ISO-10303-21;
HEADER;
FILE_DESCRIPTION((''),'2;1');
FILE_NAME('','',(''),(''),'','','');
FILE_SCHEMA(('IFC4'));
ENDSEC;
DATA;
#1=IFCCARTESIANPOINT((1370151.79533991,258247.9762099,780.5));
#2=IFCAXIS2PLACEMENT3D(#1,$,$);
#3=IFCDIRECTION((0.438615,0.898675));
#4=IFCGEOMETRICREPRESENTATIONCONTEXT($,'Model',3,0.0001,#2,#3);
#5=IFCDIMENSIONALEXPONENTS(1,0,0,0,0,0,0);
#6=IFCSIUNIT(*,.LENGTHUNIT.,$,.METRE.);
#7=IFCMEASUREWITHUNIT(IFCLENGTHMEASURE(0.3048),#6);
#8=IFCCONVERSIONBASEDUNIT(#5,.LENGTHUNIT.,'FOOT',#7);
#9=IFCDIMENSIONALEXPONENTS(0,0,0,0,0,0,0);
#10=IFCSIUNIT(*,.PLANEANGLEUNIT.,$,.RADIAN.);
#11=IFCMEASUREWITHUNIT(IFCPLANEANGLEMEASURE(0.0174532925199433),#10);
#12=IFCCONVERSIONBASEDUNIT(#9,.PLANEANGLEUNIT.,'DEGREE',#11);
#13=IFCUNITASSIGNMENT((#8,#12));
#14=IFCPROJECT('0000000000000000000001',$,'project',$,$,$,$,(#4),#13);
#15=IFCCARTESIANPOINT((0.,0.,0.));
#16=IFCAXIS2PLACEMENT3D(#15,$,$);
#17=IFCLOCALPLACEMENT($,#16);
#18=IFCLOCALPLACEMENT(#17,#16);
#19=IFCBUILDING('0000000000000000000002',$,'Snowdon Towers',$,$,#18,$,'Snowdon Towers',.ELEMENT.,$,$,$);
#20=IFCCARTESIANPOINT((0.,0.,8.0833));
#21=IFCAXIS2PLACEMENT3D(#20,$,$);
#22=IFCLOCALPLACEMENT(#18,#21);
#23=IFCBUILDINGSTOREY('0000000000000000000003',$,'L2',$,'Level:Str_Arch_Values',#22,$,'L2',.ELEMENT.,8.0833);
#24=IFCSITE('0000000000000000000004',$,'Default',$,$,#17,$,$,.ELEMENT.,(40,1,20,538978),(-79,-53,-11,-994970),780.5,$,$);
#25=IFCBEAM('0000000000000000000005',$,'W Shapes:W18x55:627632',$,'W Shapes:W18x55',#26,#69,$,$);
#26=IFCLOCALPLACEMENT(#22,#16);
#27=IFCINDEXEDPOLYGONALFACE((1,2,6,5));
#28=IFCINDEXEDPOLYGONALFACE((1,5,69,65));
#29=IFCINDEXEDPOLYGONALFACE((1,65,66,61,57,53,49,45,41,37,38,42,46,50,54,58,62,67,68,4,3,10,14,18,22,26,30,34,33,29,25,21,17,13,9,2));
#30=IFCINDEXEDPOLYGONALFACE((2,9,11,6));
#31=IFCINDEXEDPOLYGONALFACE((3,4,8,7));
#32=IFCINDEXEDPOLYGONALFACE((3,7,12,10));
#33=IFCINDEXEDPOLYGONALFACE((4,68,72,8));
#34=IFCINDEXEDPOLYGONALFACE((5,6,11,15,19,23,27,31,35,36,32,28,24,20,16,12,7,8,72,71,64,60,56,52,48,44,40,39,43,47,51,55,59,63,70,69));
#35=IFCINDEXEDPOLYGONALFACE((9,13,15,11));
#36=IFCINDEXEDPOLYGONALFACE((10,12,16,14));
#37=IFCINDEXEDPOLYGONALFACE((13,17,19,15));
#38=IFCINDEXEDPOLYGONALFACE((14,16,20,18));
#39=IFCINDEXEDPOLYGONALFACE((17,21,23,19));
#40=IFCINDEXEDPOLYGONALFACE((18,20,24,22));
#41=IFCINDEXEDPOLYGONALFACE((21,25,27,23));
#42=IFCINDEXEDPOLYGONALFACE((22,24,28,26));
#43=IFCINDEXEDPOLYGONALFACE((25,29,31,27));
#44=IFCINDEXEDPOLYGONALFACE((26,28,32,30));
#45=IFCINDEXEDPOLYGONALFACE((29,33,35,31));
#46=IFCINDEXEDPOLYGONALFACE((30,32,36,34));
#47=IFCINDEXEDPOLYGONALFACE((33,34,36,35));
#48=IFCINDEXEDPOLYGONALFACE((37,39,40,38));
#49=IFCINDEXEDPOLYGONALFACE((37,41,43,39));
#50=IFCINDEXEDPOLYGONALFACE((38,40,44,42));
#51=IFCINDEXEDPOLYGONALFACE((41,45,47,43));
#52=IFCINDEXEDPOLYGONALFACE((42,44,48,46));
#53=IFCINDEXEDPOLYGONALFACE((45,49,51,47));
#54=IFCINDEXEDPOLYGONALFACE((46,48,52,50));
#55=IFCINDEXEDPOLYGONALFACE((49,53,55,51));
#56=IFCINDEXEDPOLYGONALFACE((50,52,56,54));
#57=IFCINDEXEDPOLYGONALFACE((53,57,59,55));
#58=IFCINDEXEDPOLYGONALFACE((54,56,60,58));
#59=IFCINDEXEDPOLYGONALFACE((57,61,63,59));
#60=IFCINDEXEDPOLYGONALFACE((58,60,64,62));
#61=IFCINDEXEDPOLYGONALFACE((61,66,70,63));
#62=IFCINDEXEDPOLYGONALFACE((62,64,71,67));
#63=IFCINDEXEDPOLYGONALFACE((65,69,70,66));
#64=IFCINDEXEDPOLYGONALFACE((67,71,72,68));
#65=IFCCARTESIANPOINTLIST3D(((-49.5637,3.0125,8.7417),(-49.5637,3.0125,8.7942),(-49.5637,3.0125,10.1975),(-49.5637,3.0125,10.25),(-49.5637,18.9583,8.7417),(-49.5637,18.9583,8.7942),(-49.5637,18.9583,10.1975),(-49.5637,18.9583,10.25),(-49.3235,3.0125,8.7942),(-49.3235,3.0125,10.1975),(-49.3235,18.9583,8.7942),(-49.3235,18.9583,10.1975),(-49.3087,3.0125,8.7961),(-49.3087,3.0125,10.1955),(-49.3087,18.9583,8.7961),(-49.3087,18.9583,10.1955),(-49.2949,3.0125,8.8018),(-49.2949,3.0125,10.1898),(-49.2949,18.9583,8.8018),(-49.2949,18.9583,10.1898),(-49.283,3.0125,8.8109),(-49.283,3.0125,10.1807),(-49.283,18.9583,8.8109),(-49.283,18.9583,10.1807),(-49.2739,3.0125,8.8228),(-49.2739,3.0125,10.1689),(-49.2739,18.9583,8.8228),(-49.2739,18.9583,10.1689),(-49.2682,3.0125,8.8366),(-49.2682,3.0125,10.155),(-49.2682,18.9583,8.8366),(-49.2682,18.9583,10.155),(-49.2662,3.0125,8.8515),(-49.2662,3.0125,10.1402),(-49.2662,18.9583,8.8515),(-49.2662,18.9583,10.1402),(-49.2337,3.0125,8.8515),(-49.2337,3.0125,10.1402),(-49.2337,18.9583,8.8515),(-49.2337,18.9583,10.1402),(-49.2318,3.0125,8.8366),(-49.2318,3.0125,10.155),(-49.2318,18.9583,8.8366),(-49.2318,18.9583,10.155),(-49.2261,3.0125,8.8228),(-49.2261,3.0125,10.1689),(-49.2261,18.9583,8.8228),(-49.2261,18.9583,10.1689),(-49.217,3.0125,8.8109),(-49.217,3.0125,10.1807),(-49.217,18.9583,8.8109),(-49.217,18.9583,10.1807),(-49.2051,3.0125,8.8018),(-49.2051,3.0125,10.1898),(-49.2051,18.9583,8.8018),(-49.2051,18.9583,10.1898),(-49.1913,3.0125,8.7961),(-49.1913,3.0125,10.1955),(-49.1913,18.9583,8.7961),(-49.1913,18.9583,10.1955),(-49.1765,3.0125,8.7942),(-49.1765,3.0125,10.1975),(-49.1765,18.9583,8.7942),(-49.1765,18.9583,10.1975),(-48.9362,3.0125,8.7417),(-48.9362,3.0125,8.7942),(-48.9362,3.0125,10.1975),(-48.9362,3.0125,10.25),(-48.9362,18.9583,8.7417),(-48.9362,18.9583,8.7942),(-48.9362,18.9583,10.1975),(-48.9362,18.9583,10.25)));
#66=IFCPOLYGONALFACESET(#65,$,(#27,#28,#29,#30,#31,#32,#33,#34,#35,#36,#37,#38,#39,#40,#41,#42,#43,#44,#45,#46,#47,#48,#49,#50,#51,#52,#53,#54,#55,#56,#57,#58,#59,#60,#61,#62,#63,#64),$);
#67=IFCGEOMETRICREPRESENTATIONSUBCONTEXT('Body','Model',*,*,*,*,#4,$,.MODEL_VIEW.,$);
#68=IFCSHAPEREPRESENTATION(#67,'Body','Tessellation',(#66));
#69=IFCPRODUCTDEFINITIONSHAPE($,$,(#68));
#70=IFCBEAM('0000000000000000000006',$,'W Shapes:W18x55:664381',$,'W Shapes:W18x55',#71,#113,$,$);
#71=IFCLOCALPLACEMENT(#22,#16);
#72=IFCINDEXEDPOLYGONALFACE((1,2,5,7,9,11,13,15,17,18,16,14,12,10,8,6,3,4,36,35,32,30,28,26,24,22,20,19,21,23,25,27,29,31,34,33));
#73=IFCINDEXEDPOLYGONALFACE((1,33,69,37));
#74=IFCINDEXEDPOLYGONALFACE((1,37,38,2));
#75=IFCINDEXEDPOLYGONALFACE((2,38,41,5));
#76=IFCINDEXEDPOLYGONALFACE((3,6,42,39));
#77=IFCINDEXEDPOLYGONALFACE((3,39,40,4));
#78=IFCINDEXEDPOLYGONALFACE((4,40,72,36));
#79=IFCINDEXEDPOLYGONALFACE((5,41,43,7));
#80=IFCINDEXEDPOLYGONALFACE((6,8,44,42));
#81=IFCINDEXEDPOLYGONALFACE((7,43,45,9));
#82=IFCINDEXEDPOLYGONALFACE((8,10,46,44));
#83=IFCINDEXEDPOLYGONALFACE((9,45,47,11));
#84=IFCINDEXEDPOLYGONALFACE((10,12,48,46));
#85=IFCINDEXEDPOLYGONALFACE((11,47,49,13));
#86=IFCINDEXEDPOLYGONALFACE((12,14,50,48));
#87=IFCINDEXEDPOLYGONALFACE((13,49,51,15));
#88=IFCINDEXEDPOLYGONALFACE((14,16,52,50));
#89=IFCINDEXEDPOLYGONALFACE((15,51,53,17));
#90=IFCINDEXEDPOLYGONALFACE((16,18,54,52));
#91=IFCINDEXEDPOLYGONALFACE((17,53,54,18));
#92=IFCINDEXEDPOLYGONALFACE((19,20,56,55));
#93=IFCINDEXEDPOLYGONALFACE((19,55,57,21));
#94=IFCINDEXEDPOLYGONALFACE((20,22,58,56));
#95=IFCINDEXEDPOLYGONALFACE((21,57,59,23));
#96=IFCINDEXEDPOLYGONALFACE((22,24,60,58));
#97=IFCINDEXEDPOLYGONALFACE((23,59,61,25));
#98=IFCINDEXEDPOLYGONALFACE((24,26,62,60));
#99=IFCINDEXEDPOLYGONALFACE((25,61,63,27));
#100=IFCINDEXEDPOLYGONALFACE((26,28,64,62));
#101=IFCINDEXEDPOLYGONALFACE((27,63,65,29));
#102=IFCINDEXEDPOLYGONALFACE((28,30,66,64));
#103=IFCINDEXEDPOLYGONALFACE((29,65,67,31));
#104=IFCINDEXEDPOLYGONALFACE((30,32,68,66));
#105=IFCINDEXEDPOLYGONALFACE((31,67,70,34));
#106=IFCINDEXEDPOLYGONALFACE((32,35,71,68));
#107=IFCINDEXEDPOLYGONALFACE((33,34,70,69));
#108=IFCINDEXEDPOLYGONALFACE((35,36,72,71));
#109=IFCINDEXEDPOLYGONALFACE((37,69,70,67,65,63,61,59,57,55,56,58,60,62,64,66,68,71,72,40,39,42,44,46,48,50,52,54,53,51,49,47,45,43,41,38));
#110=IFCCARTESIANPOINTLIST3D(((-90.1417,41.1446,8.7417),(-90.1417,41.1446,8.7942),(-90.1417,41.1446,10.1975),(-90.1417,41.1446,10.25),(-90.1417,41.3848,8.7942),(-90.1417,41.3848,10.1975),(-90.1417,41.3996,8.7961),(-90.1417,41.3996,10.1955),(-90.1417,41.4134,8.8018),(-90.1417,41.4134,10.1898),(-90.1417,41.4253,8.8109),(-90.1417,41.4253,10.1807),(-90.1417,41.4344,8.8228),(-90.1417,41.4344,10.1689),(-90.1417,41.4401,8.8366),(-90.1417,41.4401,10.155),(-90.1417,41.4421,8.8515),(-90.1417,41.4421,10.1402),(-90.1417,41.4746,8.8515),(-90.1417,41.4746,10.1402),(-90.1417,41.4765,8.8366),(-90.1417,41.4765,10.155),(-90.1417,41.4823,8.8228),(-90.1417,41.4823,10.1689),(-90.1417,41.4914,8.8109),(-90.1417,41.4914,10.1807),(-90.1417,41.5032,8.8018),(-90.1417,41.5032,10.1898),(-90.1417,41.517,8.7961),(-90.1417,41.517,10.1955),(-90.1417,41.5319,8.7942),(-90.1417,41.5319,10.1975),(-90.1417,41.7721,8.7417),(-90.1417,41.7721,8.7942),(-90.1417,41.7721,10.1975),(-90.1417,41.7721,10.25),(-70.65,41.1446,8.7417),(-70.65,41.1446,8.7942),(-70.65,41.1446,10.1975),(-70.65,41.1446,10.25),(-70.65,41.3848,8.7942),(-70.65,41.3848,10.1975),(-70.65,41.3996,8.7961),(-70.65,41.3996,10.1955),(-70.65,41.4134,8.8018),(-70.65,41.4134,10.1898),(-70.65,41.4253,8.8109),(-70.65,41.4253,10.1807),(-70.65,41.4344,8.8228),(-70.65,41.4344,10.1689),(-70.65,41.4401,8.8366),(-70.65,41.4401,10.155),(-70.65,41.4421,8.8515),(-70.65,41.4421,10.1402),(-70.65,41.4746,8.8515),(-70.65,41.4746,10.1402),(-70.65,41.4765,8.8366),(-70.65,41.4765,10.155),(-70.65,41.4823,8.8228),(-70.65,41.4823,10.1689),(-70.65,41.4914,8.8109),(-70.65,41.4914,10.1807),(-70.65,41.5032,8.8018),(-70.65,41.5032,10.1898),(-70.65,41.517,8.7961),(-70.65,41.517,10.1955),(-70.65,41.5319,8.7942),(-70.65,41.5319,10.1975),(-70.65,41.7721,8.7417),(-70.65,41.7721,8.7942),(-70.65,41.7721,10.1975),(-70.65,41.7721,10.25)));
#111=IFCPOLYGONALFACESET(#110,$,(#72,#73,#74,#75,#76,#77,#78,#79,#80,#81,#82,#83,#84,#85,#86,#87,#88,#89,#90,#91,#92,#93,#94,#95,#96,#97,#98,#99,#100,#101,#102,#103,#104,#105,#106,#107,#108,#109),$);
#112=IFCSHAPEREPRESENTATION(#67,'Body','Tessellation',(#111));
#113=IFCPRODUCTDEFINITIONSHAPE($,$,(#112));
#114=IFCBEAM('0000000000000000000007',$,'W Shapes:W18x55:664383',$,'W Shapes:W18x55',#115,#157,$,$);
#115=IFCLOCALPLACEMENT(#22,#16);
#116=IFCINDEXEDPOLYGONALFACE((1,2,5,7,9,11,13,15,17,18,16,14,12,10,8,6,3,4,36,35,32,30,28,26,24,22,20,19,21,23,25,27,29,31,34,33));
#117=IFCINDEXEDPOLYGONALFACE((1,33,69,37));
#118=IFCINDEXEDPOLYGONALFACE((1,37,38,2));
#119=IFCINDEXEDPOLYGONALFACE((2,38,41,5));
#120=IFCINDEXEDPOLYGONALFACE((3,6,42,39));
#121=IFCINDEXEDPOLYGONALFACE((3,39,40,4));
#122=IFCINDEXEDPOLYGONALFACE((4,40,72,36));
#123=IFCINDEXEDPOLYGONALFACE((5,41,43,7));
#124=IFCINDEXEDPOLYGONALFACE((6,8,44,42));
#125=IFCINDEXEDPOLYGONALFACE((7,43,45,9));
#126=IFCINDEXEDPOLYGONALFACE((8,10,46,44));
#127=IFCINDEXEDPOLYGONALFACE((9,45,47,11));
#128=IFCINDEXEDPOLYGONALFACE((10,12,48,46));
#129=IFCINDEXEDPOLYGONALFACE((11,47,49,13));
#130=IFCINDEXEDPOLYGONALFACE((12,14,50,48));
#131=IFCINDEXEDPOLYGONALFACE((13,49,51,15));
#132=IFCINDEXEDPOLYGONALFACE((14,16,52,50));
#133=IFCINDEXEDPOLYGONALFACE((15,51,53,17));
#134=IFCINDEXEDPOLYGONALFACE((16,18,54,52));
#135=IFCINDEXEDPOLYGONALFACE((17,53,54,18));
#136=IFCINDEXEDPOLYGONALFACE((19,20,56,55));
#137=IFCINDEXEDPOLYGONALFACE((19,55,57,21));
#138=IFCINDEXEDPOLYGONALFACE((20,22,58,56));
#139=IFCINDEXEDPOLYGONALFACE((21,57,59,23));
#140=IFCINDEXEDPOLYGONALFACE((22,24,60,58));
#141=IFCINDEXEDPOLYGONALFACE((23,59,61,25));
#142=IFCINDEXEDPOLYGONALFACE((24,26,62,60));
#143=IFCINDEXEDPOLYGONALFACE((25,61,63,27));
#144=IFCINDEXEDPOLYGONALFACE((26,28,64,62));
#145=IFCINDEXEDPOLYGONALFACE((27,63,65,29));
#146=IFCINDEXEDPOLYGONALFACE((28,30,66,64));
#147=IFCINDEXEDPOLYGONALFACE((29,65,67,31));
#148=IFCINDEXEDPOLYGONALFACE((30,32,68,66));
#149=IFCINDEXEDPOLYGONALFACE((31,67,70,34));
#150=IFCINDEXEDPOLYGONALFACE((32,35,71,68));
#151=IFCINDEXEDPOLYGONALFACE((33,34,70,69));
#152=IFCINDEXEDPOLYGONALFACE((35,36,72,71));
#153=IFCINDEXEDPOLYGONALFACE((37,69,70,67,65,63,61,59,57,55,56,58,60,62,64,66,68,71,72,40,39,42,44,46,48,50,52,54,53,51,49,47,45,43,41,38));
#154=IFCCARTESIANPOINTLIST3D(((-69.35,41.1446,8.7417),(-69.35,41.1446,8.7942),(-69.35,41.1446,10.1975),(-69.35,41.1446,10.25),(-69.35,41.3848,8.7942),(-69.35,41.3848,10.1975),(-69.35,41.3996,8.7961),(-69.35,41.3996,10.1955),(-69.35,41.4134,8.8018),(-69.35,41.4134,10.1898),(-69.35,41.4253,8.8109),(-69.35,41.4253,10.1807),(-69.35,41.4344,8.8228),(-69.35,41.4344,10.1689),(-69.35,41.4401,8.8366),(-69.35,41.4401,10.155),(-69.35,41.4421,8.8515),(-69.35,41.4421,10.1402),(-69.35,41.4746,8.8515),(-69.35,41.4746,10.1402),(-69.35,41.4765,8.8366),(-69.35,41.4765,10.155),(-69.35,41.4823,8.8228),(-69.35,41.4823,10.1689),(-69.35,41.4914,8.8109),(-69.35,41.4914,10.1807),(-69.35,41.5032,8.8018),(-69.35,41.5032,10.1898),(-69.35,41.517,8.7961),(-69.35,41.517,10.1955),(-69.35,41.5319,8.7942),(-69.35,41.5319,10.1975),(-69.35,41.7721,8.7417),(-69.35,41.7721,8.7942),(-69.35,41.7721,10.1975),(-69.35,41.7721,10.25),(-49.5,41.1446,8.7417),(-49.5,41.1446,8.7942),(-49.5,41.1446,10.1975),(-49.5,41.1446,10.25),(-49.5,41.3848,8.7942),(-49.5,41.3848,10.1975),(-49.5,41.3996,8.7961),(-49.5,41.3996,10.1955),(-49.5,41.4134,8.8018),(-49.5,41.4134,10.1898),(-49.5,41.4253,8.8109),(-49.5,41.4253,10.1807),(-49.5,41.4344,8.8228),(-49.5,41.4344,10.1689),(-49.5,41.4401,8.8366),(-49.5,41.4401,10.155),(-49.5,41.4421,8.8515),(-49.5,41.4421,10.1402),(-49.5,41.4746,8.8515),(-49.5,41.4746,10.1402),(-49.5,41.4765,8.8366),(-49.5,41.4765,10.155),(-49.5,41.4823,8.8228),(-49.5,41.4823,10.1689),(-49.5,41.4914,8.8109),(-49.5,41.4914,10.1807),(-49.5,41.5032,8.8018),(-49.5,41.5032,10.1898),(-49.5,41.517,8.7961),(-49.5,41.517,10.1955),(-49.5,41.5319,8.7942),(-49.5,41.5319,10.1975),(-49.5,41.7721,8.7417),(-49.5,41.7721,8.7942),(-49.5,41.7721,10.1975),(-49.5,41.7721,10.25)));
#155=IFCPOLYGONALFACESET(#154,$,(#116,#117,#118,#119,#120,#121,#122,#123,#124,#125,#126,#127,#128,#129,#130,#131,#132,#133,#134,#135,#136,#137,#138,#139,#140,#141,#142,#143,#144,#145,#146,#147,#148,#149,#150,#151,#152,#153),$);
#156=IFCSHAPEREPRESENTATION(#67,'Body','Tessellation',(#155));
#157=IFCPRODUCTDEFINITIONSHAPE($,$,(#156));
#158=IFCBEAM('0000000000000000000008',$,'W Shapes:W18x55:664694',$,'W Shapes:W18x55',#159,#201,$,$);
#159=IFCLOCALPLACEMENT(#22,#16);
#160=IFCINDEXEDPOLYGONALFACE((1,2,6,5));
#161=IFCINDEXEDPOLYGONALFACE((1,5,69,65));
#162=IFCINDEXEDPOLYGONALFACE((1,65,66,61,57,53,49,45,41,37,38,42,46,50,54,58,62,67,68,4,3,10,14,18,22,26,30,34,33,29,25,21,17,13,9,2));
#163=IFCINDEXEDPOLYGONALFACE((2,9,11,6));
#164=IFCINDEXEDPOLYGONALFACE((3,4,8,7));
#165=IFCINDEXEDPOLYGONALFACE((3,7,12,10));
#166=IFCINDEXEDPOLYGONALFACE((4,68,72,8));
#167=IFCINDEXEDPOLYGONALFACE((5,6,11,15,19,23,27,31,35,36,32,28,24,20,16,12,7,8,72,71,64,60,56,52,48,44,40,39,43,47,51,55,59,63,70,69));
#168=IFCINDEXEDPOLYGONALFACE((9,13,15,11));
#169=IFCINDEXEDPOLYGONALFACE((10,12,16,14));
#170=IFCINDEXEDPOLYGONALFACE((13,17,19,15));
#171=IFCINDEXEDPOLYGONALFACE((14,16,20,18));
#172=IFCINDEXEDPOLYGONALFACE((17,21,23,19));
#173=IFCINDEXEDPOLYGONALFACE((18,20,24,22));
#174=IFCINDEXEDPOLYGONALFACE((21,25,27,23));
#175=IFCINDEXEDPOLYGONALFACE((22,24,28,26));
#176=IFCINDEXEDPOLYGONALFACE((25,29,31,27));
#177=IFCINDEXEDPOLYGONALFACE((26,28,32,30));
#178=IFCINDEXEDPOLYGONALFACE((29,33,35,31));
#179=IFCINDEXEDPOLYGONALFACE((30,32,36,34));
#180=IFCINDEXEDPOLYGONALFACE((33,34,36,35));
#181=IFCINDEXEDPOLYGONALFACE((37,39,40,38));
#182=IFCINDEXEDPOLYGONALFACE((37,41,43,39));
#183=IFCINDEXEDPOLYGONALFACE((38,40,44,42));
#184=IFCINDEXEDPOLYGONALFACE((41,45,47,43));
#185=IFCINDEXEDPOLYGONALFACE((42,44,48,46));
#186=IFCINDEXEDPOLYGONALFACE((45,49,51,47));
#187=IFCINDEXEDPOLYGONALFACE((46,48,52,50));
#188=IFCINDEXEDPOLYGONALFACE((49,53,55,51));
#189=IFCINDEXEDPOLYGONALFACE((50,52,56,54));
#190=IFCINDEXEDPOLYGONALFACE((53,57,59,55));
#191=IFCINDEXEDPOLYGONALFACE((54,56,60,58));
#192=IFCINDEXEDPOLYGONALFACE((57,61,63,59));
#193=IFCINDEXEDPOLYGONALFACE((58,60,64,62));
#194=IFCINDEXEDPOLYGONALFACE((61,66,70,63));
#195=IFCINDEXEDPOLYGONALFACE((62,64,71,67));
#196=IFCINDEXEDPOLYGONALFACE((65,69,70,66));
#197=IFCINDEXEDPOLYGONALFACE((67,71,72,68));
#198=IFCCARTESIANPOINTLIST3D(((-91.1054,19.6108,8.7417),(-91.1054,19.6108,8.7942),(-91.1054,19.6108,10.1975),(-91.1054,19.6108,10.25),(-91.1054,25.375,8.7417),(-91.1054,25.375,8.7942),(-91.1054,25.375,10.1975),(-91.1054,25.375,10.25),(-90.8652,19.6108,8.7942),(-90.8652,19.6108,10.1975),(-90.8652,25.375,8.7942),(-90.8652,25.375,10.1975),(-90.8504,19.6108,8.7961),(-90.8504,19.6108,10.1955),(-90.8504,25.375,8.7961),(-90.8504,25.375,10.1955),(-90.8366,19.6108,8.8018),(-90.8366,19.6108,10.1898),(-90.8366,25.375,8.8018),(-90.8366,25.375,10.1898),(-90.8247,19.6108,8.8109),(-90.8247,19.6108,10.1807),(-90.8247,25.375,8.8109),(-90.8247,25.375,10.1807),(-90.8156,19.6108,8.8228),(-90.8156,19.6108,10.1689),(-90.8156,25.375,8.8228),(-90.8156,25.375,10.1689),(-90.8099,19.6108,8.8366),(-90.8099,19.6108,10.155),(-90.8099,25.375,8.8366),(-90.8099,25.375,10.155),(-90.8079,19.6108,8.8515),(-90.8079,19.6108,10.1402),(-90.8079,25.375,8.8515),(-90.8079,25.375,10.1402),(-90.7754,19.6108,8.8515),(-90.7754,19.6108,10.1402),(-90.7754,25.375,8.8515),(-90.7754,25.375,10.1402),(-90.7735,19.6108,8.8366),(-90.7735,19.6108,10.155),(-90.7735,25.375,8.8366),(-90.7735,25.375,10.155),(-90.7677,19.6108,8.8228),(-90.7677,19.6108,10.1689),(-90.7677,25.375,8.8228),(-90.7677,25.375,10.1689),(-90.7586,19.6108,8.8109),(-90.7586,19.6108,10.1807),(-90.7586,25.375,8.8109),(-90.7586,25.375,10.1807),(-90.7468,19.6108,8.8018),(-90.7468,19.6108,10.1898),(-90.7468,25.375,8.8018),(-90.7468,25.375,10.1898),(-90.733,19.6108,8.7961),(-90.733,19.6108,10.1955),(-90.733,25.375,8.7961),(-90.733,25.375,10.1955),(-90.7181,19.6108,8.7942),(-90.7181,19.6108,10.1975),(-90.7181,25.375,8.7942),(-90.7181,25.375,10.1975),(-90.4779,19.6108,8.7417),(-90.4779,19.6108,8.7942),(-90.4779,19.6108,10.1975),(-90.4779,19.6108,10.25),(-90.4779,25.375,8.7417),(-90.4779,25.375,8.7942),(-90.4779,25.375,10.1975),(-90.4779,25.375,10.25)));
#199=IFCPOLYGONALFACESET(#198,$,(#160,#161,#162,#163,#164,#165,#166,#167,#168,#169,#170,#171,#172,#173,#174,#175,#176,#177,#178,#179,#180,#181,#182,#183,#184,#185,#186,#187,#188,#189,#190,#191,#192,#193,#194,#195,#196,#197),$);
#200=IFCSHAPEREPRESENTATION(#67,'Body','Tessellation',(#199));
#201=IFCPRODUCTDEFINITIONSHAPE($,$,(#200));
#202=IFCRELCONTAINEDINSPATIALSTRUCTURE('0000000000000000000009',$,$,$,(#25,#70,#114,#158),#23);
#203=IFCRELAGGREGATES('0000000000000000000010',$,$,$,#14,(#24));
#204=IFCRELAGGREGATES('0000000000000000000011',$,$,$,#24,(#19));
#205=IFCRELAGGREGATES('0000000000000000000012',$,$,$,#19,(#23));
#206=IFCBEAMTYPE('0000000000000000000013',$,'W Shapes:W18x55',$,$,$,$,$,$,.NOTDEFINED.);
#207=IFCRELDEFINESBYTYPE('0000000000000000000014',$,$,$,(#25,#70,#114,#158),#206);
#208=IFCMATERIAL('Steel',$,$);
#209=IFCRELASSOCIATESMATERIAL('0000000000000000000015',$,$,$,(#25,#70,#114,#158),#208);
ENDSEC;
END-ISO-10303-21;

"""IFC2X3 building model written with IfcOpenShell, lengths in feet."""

from ifc_helpers import new_model, entity, si_unit, converted_unit, direction, frame, frame_2d, origin, place, context, subcontext, project, spatial, i_section, extrude, material, type_object, element, save


model = new_model("IFC2X3")

# Units and contexts
model_context = context("Model", 3, precision=0.0001, world=frame((1370151.79533991, 258247.9762099, 780.5)), true_north=direction((0.438615, 0.898675)))
body_context = subcontext(model_context, "Body", "Model", "MODEL_VIEW")
ifc_project = project(units=[converted_unit("LENGTHUNIT", "FOOT", entity("IfcLengthMeasure", 0.3048), si_unit("LENGTHUNIT", "METRE"), dimensions=[1, 0, 0, 0, 0, 0, 0]), converted_unit("PLANEANGLEUNIT", "DEGREE", entity("IfcPlaneAngleMeasure", 0.0174532925199433), si_unit("PLANEANGLEUNIT", "RADIAN"), dimensions=[0, 0, 0, 0, 0, 0, 0])], contexts=[model_context])

# Site, building, storey
site_placement = place(None, origin())
site = spatial("IfcSite", under=ifc_project, at=site_placement, Name="Default", CompositionType="ELEMENT", RefLatitude=(40, 1, 20, 538978), RefLongitude=(-79, -53, -11, -994970), RefElevation=780.5)
building_placement = place(site_placement, origin())
building = spatial("IfcBuilding", under=site, at=building_placement, Name="Snowdon Towers", LongName="Snowdon Towers", CompositionType="ELEMENT")
storey_placement = place(building_placement, frame((0.0, 0.0, 8.0833)))
storey = spatial("IfcBuildingStorey", under=building, at=storey_placement, Name="L2", ObjectType="Level:Str_Arch_Values", LongName="L2", CompositionType="ELEMENT", Elevation=8.0833)

# Beams
ifc_material = material(Name="Steel")
beam_type_1 = type_object("IfcBeamType", Name="W Shapes:W18x55", PredefinedType="NOTDEFINED")
beam_1_placement = place(storey_placement, frame((-49.25, 19.2083, 10.25), z_axis=(0.0, 0.0, 1.0), x_axis=(0.0, -1.0, 0.0)))
element("IfcBeam", 1, at=beam_1_placement, inside=storey, type_object=beam_type_1, material=ifc_material, Name="W Shapes:W18x55:627632", ObjectType="W Shapes:W18x55", context=body_context, shape_type="SweptSolid", body=[
    extrude(i_section(OverallWidth=0.6275, OverallDepth=1.5083, WebThickness=0.0325, FlangeThickness=0.0525, FilletRadius=0.0573, at=frame_2d((0.0, 0.0), x_axis=(0.0, 1.0))), frame((0.25, 0.0, -0.7542), z_axis=(1.0, 0.0, 0.0), x_axis=(0.0, 0.0, -1.0)), (0.0, 0.0, 1.0), 15.9458),
])
beam_2_placement = place(storey_placement, frame((-90.7083, 41.4583, 10.25)))
element("IfcBeam", 2, at=beam_2_placement, inside=storey, type_object=beam_type_1, material=ifc_material, Name="W Shapes:W18x55:664381", ObjectType="W Shapes:W18x55", context=body_context, shape_type="SweptSolid", body=[
    extrude(i_section(OverallWidth=0.6275, OverallDepth=1.5083, WebThickness=0.0325, FlangeThickness=0.0525, FilletRadius=0.0573, at=frame_2d((0.0, 0.0), x_axis=(0.0, 1.0))), frame((0.5667, 0.0, -0.7542), z_axis=(1.0, 0.0, 0.0), x_axis=(0.0, 0.0, -1.0)), (0.0, 0.0, 1.0), 19.4917),
])
beam_3_placement = place(storey_placement, frame((-70.0, 41.4583, 10.25)))
element("IfcBeam", 3, at=beam_3_placement, inside=storey, type_object=beam_type_1, material=ifc_material, Name="W Shapes:W18x55:664383", ObjectType="W Shapes:W18x55", context=body_context, shape_type="SweptSolid", body=[
    extrude(i_section(OverallWidth=0.6275, OverallDepth=1.5083, WebThickness=0.0325, FlangeThickness=0.0525, FilletRadius=0.0573, at=frame_2d((0.0, 0.0), x_axis=(0.0, 1.0))), frame((0.65, 0.0, -0.7542), z_axis=(1.0, 0.0, 0.0), x_axis=(0.0, 0.0, -1.0)), (0.0, 0.0, 1.0), 19.85),
])
beam_4_placement = place(storey_placement, frame((-90.7917, 19.1942, 10.25), z_axis=(0.0, 0.0, 1.0), x_axis=(0.0, 1.0, 0.0)))
element("IfcBeam", 4, at=beam_4_placement, inside=storey, type_object=beam_type_1, material=ifc_material, Name="W Shapes:W18x55:664694", ObjectType="W Shapes:W18x55", context=body_context, shape_type="SweptSolid", body=[
    extrude(i_section(OverallWidth=0.6275, OverallDepth=1.5083, WebThickness=0.0325, FlangeThickness=0.0525, FilletRadius=0.0573, at=frame_2d((0.0, 0.0), x_axis=(0.0, 1.0))), frame((0.4167, 0.0, -0.7542), z_axis=(1.0, 0.0, 0.0), x_axis=(0.0, 0.0, -1.0)), (0.0, 0.0, 1.0), 5.7642),
])

save(model, "model.ifc")
